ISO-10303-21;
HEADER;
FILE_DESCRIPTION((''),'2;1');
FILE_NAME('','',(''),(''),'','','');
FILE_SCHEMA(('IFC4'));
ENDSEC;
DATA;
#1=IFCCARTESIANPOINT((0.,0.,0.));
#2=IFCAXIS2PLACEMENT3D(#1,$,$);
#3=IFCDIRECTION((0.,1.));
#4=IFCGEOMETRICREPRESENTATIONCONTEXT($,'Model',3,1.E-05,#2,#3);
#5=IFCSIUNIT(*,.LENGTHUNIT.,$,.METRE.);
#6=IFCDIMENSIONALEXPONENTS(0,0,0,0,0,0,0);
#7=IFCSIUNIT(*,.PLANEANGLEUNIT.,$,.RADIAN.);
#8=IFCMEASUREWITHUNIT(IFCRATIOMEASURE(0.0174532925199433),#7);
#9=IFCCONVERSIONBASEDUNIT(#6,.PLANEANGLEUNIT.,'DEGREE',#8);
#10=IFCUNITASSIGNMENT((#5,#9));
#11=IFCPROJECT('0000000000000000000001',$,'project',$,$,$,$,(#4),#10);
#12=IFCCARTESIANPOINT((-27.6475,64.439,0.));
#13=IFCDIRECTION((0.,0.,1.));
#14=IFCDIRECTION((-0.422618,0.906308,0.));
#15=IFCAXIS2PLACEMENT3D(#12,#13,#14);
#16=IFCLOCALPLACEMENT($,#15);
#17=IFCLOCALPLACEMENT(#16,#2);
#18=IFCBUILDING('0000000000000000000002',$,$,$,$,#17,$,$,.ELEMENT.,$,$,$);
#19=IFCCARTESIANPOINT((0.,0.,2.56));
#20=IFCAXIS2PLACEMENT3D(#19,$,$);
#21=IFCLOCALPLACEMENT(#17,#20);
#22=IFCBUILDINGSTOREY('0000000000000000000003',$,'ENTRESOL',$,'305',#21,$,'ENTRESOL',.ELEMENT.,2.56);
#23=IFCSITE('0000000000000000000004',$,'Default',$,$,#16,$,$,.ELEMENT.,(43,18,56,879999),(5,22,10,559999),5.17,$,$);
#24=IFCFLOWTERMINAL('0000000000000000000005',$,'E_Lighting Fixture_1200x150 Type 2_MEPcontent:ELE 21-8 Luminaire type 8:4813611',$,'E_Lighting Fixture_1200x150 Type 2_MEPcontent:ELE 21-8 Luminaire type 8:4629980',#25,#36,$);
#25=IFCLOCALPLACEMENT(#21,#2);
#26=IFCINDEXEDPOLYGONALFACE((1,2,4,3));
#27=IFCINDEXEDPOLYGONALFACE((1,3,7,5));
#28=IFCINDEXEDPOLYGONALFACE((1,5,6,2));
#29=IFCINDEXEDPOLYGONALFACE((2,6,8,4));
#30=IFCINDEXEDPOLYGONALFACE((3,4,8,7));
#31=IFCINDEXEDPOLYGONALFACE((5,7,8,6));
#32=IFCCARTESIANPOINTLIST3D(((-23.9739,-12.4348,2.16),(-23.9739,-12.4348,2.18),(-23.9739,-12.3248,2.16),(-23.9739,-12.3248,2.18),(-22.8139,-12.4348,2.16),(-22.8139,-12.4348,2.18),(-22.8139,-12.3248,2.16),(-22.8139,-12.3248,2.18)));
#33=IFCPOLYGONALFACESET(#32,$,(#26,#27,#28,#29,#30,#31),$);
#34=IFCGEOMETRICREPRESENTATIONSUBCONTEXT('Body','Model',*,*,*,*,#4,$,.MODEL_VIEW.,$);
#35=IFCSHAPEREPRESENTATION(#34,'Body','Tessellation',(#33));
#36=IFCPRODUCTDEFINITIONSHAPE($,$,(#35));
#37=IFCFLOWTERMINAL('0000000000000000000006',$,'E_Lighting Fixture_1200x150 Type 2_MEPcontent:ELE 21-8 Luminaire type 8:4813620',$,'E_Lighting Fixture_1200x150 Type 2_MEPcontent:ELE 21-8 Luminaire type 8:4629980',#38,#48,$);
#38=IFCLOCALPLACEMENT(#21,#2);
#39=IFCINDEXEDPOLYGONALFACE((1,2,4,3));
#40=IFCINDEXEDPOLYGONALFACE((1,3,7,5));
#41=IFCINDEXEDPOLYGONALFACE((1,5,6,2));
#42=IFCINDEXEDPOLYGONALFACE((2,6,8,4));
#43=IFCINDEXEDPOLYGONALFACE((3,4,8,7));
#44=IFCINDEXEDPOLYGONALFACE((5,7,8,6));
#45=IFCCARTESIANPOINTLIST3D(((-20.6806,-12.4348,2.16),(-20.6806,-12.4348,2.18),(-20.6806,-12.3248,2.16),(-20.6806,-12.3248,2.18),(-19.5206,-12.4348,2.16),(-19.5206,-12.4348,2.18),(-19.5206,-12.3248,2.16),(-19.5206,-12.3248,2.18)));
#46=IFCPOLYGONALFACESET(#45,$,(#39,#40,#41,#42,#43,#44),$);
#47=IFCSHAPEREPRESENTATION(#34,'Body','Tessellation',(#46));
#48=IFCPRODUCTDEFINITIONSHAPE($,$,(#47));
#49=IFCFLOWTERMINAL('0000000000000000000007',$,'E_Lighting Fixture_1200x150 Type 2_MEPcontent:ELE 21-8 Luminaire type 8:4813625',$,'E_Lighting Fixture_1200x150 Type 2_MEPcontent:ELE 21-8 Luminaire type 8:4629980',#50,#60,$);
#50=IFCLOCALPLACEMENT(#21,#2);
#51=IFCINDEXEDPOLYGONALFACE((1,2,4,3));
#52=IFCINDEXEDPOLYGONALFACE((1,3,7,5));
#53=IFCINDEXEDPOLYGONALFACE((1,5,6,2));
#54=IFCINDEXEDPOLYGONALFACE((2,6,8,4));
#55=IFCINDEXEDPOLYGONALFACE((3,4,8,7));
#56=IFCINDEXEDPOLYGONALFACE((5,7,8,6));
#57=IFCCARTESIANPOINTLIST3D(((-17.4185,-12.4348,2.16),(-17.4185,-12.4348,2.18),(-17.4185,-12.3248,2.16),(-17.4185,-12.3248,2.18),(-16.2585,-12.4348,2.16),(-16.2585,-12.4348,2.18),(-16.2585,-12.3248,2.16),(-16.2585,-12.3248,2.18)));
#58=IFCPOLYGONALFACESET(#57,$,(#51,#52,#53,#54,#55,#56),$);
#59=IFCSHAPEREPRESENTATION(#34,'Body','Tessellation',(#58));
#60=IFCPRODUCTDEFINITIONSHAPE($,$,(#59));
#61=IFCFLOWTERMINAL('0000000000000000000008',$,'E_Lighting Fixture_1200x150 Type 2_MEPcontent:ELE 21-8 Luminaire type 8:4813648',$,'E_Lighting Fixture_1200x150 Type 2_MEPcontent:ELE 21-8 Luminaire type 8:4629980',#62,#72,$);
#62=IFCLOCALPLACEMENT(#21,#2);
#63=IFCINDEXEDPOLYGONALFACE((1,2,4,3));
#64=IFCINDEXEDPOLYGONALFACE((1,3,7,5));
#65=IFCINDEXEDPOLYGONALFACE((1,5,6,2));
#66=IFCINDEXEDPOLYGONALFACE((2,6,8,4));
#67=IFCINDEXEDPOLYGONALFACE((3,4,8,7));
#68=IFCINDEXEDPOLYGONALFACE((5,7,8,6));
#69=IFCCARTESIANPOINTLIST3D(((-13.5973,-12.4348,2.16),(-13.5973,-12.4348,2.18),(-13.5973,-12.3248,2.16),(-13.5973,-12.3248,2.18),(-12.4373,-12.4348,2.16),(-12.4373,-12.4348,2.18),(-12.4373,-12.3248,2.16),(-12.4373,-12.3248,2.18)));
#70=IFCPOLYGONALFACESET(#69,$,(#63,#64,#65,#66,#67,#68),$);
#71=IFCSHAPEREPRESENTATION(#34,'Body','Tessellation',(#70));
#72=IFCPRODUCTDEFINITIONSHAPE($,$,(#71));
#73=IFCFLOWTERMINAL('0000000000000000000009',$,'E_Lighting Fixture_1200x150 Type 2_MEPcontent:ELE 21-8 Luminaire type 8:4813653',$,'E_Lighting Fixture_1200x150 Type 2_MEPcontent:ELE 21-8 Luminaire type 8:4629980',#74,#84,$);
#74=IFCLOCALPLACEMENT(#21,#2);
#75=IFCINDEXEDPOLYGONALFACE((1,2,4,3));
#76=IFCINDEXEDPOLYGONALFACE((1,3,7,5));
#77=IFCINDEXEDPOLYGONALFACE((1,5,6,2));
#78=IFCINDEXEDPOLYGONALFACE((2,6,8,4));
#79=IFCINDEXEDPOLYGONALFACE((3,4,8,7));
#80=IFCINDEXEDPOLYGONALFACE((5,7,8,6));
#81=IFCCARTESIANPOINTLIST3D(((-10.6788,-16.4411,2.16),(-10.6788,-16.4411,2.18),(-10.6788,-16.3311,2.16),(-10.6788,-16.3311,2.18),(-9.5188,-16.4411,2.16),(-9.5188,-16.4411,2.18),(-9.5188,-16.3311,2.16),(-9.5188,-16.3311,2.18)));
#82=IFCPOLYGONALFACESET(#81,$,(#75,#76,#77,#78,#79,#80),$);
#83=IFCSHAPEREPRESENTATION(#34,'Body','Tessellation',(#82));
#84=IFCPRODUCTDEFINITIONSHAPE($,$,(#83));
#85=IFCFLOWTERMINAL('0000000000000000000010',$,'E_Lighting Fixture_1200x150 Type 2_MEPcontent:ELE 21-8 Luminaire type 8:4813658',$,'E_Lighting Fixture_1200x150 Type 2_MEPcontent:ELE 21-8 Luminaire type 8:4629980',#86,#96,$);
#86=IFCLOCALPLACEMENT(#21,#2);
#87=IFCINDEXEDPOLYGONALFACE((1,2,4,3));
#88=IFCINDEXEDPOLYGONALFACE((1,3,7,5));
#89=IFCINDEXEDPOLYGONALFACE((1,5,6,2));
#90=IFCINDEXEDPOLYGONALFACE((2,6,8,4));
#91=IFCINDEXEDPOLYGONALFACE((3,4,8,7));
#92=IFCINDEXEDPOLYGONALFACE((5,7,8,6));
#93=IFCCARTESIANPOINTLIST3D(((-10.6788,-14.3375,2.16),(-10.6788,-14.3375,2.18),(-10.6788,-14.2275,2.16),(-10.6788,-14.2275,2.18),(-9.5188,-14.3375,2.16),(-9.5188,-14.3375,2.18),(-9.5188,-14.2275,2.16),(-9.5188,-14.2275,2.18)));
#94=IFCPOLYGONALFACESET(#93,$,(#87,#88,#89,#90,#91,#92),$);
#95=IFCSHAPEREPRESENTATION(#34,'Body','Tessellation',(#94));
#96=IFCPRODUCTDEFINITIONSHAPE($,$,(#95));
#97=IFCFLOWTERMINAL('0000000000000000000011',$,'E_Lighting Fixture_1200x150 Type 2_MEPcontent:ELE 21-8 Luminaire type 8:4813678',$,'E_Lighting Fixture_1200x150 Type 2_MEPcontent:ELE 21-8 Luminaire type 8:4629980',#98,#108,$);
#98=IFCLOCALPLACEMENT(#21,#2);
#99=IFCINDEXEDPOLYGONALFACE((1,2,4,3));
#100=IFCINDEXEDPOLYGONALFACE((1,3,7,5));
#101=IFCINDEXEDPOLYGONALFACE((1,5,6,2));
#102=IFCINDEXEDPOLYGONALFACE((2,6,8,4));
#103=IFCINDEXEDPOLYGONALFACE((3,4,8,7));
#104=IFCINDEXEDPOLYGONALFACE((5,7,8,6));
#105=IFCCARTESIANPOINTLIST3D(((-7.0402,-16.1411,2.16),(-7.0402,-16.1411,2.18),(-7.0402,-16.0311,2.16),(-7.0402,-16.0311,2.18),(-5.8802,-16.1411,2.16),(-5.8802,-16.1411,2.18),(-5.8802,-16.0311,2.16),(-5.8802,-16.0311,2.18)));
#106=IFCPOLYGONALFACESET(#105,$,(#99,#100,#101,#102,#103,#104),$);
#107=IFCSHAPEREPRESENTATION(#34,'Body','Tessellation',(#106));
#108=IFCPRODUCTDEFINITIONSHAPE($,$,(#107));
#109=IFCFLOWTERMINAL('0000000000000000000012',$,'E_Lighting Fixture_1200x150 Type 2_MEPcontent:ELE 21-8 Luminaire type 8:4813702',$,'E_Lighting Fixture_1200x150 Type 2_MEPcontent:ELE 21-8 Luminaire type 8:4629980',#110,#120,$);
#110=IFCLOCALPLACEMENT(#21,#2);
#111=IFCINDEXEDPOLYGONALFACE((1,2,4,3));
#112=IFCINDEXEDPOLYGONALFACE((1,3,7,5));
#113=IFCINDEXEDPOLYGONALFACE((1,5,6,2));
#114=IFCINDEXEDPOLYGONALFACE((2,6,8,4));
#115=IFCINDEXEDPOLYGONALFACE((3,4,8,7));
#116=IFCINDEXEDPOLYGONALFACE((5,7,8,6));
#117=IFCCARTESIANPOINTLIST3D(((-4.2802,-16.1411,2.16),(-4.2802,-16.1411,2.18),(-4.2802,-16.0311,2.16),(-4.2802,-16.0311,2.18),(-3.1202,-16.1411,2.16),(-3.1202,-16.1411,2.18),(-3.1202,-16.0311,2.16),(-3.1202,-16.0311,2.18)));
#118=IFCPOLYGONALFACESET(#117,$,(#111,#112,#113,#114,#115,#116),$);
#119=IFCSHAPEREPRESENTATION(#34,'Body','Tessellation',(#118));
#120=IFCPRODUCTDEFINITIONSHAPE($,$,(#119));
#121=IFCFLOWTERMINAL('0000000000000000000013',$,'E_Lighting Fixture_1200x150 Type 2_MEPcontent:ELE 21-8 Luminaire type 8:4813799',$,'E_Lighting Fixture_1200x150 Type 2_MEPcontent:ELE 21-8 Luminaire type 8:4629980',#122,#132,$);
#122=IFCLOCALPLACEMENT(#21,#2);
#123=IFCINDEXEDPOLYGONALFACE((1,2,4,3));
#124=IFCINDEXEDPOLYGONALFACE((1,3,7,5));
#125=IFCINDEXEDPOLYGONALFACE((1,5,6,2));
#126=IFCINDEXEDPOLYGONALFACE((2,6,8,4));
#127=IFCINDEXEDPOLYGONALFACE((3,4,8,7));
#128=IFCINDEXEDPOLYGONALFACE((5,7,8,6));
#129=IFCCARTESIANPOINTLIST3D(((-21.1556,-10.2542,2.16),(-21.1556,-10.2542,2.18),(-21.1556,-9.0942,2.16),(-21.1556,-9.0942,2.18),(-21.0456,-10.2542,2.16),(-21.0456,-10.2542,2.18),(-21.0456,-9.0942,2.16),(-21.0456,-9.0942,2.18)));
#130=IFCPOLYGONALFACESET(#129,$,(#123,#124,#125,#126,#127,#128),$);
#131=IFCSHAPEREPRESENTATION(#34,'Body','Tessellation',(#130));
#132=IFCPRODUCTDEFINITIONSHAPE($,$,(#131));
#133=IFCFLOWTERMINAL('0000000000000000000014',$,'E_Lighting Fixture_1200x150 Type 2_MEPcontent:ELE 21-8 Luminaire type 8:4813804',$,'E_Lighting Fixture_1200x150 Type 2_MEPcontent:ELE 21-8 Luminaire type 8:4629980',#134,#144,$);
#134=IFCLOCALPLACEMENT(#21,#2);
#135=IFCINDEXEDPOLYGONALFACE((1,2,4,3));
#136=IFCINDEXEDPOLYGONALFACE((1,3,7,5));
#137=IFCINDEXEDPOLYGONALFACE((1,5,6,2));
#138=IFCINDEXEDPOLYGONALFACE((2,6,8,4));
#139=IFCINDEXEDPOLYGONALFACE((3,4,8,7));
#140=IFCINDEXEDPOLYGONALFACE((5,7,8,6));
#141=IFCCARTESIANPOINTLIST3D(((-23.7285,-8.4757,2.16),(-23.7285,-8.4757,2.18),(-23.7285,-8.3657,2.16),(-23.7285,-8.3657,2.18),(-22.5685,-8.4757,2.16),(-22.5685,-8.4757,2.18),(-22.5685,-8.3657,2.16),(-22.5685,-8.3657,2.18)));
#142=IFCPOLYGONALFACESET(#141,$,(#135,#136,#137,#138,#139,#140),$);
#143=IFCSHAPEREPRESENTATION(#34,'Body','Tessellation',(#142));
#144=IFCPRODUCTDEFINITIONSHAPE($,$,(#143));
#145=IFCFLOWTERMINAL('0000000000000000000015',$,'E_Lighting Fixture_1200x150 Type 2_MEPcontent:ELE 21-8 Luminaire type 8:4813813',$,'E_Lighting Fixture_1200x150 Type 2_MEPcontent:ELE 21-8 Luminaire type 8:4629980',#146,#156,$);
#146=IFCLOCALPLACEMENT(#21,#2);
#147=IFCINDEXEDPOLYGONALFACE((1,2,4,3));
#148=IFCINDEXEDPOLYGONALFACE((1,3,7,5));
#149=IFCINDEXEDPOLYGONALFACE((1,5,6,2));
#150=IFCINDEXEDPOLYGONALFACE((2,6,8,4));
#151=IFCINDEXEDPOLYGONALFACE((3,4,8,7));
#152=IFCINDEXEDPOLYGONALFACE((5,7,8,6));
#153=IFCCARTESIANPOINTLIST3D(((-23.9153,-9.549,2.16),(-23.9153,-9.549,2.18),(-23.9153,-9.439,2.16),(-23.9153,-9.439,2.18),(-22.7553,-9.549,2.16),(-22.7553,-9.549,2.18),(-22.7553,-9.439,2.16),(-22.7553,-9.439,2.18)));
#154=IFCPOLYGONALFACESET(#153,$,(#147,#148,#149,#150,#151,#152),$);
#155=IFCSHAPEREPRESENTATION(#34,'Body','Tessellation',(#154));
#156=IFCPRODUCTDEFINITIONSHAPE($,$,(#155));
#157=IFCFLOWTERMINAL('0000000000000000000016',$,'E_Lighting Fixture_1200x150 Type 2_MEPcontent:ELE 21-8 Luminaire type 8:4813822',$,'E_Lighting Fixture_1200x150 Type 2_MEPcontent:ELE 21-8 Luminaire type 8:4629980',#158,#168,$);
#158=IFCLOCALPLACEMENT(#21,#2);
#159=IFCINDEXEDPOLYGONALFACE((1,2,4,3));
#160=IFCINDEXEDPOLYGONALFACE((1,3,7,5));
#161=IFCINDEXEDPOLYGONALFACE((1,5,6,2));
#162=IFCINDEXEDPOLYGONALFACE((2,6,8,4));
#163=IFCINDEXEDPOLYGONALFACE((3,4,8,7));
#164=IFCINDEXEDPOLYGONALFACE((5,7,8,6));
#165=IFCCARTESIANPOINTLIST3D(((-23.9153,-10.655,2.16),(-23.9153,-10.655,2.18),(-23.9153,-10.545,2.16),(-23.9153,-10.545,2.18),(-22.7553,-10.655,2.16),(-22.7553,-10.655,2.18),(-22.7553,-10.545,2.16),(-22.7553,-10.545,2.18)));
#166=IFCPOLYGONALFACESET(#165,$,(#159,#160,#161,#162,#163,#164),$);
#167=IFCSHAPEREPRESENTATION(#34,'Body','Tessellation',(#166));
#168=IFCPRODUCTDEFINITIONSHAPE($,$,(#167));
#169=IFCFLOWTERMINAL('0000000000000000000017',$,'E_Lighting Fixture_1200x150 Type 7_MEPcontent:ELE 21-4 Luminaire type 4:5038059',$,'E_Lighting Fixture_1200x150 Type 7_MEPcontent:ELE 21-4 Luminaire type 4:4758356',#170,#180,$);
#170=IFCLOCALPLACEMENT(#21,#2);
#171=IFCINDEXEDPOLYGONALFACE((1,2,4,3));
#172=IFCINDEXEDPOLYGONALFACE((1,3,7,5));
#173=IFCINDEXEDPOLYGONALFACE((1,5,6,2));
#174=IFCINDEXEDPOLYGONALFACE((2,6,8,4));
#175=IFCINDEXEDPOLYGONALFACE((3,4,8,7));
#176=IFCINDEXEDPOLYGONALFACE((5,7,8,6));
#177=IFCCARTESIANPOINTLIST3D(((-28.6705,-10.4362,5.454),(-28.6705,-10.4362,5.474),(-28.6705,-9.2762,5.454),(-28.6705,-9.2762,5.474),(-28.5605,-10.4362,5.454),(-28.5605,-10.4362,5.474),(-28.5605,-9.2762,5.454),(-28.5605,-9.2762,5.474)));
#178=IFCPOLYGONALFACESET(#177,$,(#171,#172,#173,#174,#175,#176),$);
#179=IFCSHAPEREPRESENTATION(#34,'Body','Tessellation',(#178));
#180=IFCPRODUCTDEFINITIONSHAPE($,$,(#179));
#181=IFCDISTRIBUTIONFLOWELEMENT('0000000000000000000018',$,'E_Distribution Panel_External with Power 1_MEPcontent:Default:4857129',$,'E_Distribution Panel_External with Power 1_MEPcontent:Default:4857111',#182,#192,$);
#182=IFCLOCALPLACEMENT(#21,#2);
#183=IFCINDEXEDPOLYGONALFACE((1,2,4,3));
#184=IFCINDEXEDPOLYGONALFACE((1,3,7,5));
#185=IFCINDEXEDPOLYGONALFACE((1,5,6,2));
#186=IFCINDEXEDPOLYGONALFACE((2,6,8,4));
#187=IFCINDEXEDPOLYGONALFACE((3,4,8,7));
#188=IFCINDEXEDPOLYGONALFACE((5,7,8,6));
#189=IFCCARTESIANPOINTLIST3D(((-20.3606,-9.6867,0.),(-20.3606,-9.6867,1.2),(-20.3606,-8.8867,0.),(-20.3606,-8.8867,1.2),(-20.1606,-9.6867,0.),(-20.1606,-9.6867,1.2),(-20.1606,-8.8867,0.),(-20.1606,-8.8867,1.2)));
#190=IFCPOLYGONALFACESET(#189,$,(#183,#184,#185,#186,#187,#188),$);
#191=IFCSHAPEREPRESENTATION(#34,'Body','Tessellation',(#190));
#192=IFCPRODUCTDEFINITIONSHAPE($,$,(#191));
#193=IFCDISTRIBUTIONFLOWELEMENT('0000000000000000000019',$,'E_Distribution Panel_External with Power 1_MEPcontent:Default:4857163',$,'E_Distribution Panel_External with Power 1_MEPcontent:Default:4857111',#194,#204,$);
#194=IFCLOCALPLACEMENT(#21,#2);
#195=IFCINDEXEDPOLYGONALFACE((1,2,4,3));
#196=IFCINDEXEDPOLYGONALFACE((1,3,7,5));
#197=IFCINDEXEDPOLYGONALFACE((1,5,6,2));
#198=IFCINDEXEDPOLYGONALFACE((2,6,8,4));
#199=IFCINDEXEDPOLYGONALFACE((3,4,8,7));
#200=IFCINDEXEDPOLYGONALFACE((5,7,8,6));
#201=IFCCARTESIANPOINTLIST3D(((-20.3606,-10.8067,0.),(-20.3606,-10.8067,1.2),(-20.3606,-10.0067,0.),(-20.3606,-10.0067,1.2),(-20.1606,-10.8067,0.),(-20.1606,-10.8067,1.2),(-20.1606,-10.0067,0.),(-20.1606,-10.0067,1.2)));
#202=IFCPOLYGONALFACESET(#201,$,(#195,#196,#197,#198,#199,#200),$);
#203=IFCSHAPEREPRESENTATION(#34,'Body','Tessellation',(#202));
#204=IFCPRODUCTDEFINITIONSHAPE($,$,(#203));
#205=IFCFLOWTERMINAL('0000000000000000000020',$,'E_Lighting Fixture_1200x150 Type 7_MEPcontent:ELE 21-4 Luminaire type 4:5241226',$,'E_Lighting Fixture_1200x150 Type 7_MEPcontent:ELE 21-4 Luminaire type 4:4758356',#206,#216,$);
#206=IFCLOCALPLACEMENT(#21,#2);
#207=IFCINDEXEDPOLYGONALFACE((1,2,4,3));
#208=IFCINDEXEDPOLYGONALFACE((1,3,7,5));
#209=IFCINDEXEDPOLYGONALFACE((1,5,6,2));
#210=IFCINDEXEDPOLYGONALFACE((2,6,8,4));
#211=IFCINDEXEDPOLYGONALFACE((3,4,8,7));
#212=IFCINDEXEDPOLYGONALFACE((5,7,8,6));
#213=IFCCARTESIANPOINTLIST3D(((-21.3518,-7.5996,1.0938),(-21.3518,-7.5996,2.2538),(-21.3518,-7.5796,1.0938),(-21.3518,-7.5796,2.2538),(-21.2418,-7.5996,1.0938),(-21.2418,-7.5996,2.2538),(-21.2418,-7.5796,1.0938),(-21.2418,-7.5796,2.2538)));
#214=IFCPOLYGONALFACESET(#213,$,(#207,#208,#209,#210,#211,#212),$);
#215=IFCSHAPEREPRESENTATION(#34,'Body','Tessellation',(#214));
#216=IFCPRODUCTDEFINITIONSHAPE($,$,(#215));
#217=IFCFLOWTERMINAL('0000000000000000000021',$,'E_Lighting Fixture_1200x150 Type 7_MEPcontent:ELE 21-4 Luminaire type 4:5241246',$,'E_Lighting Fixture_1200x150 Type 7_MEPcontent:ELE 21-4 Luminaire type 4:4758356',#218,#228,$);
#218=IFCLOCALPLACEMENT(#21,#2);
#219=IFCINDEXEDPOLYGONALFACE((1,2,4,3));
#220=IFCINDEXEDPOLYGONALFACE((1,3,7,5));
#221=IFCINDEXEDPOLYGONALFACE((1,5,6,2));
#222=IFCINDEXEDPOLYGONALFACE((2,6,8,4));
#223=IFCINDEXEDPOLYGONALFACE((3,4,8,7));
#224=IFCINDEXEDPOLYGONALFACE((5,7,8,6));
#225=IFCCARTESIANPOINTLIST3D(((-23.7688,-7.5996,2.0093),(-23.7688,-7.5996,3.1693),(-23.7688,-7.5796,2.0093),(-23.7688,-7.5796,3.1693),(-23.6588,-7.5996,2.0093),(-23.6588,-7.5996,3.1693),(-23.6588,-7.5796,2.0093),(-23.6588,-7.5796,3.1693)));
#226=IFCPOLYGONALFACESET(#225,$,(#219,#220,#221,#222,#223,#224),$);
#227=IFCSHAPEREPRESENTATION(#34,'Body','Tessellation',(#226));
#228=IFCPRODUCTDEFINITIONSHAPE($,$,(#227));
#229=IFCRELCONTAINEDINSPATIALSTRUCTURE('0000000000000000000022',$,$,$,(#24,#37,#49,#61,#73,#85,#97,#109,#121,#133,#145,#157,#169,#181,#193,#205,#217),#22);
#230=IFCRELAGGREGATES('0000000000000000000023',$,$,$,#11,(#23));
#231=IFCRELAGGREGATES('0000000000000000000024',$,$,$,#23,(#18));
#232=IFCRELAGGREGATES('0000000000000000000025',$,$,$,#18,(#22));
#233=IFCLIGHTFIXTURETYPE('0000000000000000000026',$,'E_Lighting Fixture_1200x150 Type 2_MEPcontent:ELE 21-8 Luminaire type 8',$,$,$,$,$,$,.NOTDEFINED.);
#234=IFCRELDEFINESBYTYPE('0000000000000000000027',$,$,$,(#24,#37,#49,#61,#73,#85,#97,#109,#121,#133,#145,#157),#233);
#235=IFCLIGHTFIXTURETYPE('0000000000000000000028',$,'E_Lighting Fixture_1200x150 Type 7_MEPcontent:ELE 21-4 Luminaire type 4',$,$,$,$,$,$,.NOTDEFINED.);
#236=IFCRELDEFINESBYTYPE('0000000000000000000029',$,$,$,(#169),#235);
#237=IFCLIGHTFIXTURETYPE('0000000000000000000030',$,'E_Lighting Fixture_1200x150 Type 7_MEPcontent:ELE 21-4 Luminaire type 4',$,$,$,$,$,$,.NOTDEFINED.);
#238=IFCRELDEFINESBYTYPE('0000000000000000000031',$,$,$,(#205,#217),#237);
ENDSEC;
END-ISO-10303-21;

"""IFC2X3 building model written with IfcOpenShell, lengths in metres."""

from ifc_helpers import new_model, entity, si_unit, converted_unit, direction, frame, frame_2d, origin, origin_2d_with_axis, place, context, subcontext, project, spatial, rectangle, extrude, source, transform, mapped, type_object, type_shapes, element, save


model = new_model("IFC2X3")

# Units and contexts
model_context = context("Model", 3, precision=1e-05, world=origin(), true_north=direction((0.0, 1.0)))
body_context = subcontext(model_context, "Body", "Model", "MODEL_VIEW")
ifc_project = project(units=[si_unit("LENGTHUNIT", "METRE"), converted_unit("PLANEANGLEUNIT", "DEGREE", entity("IfcRatioMeasure", 0.0174532925199433), si_unit("PLANEANGLEUNIT", "RADIAN"), dimensions=[0, 0, 0, 0, 0, 0, 0])], contexts=[model_context])

# Site, building, storey
site_placement = place(None, frame((-27.6475, 64.439, 0.0), z_axis=(0.0, 0.0, 1.0), x_axis=(-0.422618, 0.906308, 0.0)))
site = spatial("IfcSite", under=ifc_project, at=site_placement, Name="Default", CompositionType="ELEMENT", RefLatitude=(43, 18, 56, 879999), RefLongitude=(5, 22, 10, 559999), RefElevation=5.17)
building_placement = place(site_placement, origin())
building = spatial("IfcBuilding", under=site, at=building_placement, CompositionType="ELEMENT")
storey_placement = place(building_placement, frame((0.0, 0.0, 2.56)))
storey = spatial("IfcBuildingStorey", under=building, at=storey_placement, Name="ENTRESOL", ObjectType="305", LongName="ENTRESOL", CompositionType="ELEMENT", Elevation=2.56)

# Flow terminals
light_fixture_type_1 = type_object("IfcLightFixtureType", Name="E_Lighting Fixture_1200x150 Type 2_MEPcontent:ELE 21-8 Luminaire type 8", PredefinedType="NOTDEFINED")
shared_shape_1 = source(origin(), body_context, "Body", "SweptSolid", [
    extrude(rectangle(XDim=0.11, YDim=1.16, at=origin_2d_with_axis()), frame((0.0, 0.0, 0.0), z_axis=(0.0, 0.0, 1.0), x_axis=(0.0, -1.0, 0.0)), (0.0, 0.0, 1.0), 0.02),
])
type_shapes(light_fixture_type_1, [shared_shape_1])
for number, where, name in (
    (1, (-23.3939, -12.3798, 2.16), "E_Lighting Fixture_1200x150 Type 2_MEPcontent:ELE 21-8 Luminaire type 8:4813611"),
    (2, (-20.1006, -12.3798, 2.16), "E_Lighting Fixture_1200x150 Type 2_MEPcontent:ELE 21-8 Luminaire type 8:4813620"),
    (3, (-16.8385, -12.3798, 2.16), "E_Lighting Fixture_1200x150 Type 2_MEPcontent:ELE 21-8 Luminaire type 8:4813625"),
    (4, (-13.0173, -12.3798, 2.16), "E_Lighting Fixture_1200x150 Type 2_MEPcontent:ELE 21-8 Luminaire type 8:4813648"),
    (5, (-10.0988, -16.3861, 2.16), "E_Lighting Fixture_1200x150 Type 2_MEPcontent:ELE 21-8 Luminaire type 8:4813653"),
    (6, (-10.0988, -14.2825, 2.16), "E_Lighting Fixture_1200x150 Type 2_MEPcontent:ELE 21-8 Luminaire type 8:4813658"),
    (7, (-6.4602, -16.0861, 2.16), "E_Lighting Fixture_1200x150 Type 2_MEPcontent:ELE 21-8 Luminaire type 8:4813678"),
    (8, (-3.7002, -16.0861, 2.16), "E_Lighting Fixture_1200x150 Type 2_MEPcontent:ELE 21-8 Luminaire type 8:4813702"),
):
    element("IfcFlowTerminal", number, at=place(storey_placement, frame(where)), inside=storey, type_object=light_fixture_type_1, Name=name, ObjectType="E_Lighting Fixture_1200x150 Type 2_MEPcontent:ELE 21-8 Luminaire type 8:4629980", context=body_context, shape_type="MappedRepresentation", body=[
        mapped(shared_shape_1, transform((0.0, 0.0, 0.0), scale=1.0)),
    ])
flow_terminal_1_placement = place(storey_placement, frame((-21.1006, -9.6742, 2.16), z_axis=(0.0, 0.0, 1.0), x_axis=(0.0, -1.0, 0.0)))
element("IfcFlowTerminal", 9, at=flow_terminal_1_placement, inside=storey, type_object=light_fixture_type_1, Name="E_Lighting Fixture_1200x150 Type 2_MEPcontent:ELE 21-8 Luminaire type 8:4813799", ObjectType="E_Lighting Fixture_1200x150 Type 2_MEPcontent:ELE 21-8 Luminaire type 8:4629980", context=body_context, shape_type="MappedRepresentation", body=[
    mapped(shared_shape_1, transform((0.0, 0.0, 0.0), scale=1.0)),
])
for number, where, name in (
    (10, (-23.1485, -8.4207, 2.16), "E_Lighting Fixture_1200x150 Type 2_MEPcontent:ELE 21-8 Luminaire type 8:4813804"),
    (11, (-23.3353, -9.494, 2.16), "E_Lighting Fixture_1200x150 Type 2_MEPcontent:ELE 21-8 Luminaire type 8:4813813"),
    (12, (-23.3353, -10.6, 2.16), "E_Lighting Fixture_1200x150 Type 2_MEPcontent:ELE 21-8 Luminaire type 8:4813822"),
):
    element("IfcFlowTerminal", number, at=place(storey_placement, frame(where)), inside=storey, type_object=light_fixture_type_1, Name=name, ObjectType="E_Lighting Fixture_1200x150 Type 2_MEPcontent:ELE 21-8 Luminaire type 8:4629980", context=body_context, shape_type="MappedRepresentation", body=[
        mapped(shared_shape_1, transform((0.0, 0.0, 0.0), scale=1.0)),
    ])
light_fixture_type_2 = type_object("IfcLightFixtureType", Name="E_Lighting Fixture_1200x150 Type 7_MEPcontent:ELE 21-4 Luminaire type 4", PredefinedType="NOTDEFINED")
shared_shape_2 = source(origin(), body_context, "Body", "SweptSolid", [
    extrude(rectangle(XDim=0.11, YDim=1.16, at=origin_2d_with_axis()), frame((0.0, 0.0, 0.0), z_axis=(0.0, 0.0, 1.0), x_axis=(0.0, -1.0, 0.0)), (0.0, 0.0, 1.0), 0.02),
])
type_shapes(light_fixture_type_2, [shared_shape_2])
flow_terminal_2_placement = place(storey_placement, frame((-28.6155, -9.8562, 5.454), z_axis=(0.0, 0.0, 1.0), x_axis=(0.0, -1.0, 0.0)))
element("IfcFlowTerminal", 13, at=flow_terminal_2_placement, inside=storey, type_object=light_fixture_type_2, Name="E_Lighting Fixture_1200x150 Type 7_MEPcontent:ELE 21-4 Luminaire type 4:5038059", ObjectType="E_Lighting Fixture_1200x150 Type 7_MEPcontent:ELE 21-4 Luminaire type 4:4758356", context=body_context, shape_type="MappedRepresentation", body=[
    mapped(shared_shape_2, transform((0.0, 0.0, 0.0), scale=1.0)),
])

# Distribution flow elements
shared_shape_3 = source(origin(), body_context, "Body", "SweptSolid", [
    extrude(rectangle(XDim=0.2, YDim=0.8, at=origin_2d_with_axis()), frame((0.0, 0.1, 0.0), z_axis=(0.0, 0.0, 1.0), x_axis=(0.0, -1.0, 0.0)), (0.0, 0.0, 1.0), 1.2),
])
for number, where, z_axis, x_axis, name in (
    (14, (-20.1606, -9.2867, 0.0), (0.0, 0.0, 1.0), (0.0, 1.0, 0.0), "E_Distribution Panel_External with Power 1_MEPcontent:Default:4857129"),
    (15, (-20.1606, -10.4067, 0.0), (0.0, 0.0, 1.0), (0.0, 1.0, 0.0), "E_Distribution Panel_External with Power 1_MEPcontent:Default:4857163"),
):
    element("IfcDistributionFlowElement", number, at=place(storey_placement, frame(where, z_axis=z_axis, x_axis=x_axis)), inside=storey, Name=name, ObjectType="E_Distribution Panel_External with Power 1_MEPcontent:Default:4857111", context=body_context, shape_type="MappedRepresentation", body=[
        mapped(shared_shape_3, transform((0.0, 0.0, 0.0), scale=1.0)),
    ])

# Flow terminals
light_fixture_type_3 = type_object("IfcLightFixtureType", Name="E_Lighting Fixture_1200x150 Type 7_MEPcontent:ELE 21-4 Luminaire type 4", PredefinedType="NOTDEFINED")
shared_shape_4 = source(origin(), body_context, "Body", "SweptSolid", [
    extrude(rectangle(XDim=0.02, YDim=0.11, at=frame_2d((0.0, 0.0), x_axis=(1.0, 0.0))), frame((0.0, 0.01, -0.58), z_axis=(0.0, 0.0, 1.0), x_axis=(0.0, -1.0, 0.0)), (0.0, 0.0, 1.0), 1.16),
])
type_shapes(light_fixture_type_3, [shared_shape_4])
for number, where, name in (
    (16, (-21.2968, -7.5996, 1.6738), "E_Lighting Fixture_1200x150 Type 7_MEPcontent:ELE 21-4 Luminaire type 4:5241226"),
    (17, (-23.7138, -7.5996, 2.5893), "E_Lighting Fixture_1200x150 Type 7_MEPcontent:ELE 21-4 Luminaire type 4:5241246"),
):
    element("IfcFlowTerminal", number, at=place(storey_placement, frame(where)), inside=storey, type_object=light_fixture_type_3, Name=name, ObjectType="E_Lighting Fixture_1200x150 Type 7_MEPcontent:ELE 21-4 Luminaire type 4:4758356", context=body_context, shape_type="MappedRepresentation", body=[
        mapped(shared_shape_4, transform((0.0, 0.0, 0.0), scale=1.0)),
    ])

save(model, "model.ifc")
